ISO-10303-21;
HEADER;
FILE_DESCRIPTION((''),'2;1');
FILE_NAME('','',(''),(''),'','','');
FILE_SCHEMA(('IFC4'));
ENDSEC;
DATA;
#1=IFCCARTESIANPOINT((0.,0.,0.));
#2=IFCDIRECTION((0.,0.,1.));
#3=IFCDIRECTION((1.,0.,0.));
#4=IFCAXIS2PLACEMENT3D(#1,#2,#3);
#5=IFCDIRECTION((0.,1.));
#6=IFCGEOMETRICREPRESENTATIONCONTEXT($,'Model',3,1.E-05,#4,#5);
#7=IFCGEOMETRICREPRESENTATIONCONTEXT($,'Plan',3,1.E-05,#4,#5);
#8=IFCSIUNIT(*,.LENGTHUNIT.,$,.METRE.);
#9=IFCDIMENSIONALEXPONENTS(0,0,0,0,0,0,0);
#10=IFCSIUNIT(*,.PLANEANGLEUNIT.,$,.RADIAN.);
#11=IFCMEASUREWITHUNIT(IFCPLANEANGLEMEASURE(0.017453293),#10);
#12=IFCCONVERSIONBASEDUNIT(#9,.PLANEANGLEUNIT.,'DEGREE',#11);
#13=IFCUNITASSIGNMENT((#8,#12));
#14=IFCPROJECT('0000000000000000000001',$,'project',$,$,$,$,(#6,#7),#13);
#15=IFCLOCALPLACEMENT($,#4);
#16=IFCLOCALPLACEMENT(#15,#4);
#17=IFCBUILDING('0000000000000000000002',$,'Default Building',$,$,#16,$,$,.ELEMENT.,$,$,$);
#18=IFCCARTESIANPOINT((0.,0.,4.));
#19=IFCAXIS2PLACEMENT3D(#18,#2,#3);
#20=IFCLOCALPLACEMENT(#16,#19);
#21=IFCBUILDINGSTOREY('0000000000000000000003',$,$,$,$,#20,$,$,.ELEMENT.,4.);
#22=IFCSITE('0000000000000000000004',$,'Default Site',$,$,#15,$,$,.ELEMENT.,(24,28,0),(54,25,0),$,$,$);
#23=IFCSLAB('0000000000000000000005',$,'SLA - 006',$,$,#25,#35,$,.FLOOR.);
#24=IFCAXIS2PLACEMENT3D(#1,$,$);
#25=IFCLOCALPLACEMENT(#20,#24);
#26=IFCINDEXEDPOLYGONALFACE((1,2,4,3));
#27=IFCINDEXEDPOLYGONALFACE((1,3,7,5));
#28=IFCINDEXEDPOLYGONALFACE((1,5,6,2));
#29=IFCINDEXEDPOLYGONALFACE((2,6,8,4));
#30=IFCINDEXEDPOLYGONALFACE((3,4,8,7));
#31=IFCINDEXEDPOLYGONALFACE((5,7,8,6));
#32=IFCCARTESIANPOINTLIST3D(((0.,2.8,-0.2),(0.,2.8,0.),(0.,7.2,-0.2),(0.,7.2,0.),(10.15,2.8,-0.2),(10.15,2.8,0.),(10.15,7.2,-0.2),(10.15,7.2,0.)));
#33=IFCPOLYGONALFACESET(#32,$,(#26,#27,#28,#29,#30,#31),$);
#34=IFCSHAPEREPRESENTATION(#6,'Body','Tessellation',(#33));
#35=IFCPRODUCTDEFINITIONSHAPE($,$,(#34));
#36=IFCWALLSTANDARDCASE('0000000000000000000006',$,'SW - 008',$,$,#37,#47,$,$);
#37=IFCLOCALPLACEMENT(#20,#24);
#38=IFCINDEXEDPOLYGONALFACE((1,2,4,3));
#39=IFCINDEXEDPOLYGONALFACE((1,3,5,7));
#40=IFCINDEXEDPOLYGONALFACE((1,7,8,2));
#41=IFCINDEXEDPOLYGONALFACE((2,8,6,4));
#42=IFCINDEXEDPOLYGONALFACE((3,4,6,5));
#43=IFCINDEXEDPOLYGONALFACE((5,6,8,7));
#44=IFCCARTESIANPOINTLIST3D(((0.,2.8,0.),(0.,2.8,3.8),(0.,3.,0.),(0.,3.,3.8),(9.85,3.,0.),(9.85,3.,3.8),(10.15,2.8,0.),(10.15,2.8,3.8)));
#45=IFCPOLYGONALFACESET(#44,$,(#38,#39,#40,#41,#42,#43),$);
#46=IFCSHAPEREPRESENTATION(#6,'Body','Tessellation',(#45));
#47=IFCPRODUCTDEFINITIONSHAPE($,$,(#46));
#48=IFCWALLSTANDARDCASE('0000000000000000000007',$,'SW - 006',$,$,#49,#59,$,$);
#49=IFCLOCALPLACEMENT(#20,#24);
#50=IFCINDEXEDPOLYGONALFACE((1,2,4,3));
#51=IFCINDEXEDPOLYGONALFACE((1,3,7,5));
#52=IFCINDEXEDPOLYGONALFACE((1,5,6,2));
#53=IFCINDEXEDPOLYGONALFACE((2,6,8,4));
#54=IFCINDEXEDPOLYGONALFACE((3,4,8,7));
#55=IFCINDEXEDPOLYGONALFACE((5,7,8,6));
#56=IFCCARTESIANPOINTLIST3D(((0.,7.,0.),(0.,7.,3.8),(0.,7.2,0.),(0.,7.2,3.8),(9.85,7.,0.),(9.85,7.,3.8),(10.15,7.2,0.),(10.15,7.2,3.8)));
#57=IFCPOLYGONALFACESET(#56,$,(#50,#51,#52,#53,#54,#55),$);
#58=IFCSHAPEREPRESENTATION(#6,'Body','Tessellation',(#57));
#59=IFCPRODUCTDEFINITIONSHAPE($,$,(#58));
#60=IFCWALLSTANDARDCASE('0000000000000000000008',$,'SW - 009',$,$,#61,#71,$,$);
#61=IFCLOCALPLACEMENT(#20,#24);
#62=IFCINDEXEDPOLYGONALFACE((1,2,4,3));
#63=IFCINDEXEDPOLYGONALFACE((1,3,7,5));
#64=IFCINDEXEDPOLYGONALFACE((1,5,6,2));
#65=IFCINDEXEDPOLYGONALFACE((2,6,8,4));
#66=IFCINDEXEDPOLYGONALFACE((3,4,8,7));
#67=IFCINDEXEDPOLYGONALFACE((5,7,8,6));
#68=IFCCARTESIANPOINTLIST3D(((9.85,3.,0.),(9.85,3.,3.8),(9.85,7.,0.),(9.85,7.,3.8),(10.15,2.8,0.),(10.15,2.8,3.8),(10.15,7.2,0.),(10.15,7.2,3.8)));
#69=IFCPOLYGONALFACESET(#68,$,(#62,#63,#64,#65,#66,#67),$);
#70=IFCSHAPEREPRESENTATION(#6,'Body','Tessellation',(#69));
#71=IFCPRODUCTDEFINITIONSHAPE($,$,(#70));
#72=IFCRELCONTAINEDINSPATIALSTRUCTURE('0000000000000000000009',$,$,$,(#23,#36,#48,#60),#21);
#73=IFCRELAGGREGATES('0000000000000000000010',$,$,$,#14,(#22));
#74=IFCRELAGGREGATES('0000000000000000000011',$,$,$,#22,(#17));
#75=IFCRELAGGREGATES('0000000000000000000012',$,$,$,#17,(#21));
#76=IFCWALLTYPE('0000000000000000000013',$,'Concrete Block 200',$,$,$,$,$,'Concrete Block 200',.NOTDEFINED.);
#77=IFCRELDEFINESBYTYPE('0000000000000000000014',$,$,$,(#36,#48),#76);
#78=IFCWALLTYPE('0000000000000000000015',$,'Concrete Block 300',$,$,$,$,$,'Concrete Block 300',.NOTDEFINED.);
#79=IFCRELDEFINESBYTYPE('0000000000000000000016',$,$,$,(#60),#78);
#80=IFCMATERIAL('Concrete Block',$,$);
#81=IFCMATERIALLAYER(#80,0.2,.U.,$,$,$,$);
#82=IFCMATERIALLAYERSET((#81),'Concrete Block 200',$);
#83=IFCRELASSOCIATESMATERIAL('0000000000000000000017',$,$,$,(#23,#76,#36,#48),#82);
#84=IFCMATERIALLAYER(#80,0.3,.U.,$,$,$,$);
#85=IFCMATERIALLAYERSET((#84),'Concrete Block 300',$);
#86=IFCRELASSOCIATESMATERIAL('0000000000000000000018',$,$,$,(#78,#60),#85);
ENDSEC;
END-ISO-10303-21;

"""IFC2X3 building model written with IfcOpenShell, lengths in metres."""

from ifc_helpers import new_model, entity, si_unit, converted_unit, direction, frame, origin_with_axes, place, context, project, spatial, polyline, outline, extrude, material, layer, layer_set, layer_usage, type_object, element, save


model = new_model("IFC2X3")

# Units and contexts
model_context = context("Model", 3, precision=1e-05, world=origin_with_axes(), true_north=direction((0.0, 1.0)))
plan_context = context("Plan", 3, precision=1e-05, world=origin_with_axes(), true_north=direction((0.0, 1.0)))
ifc_project = project(units=[si_unit("LENGTHUNIT", "METRE"), converted_unit("PLANEANGLEUNIT", "DEGREE", entity("IfcPlaneAngleMeasure", 0.017453293), si_unit("PLANEANGLEUNIT", "RADIAN"), dimensions=[0, 0, 0, 0, 0, 0, 0])], contexts=[model_context, plan_context])

# Site, building, storey
site_placement = place(None, origin_with_axes())
site = spatial("IfcSite", under=ifc_project, at=site_placement, Name="Default Site", CompositionType="ELEMENT", RefLatitude=(24, 28, 0), RefLongitude=(54, 25, 0))
building_placement = place(site_placement, origin_with_axes())
building = spatial("IfcBuilding", under=site, at=building_placement, Name="Default Building", CompositionType="ELEMENT")
storey_placement = place(building_placement, frame((0.0, 0.0, 4.0), z_axis=(0.0, 0.0, 1.0), x_axis=(1.0, 0.0, 0.0)))
storey = spatial("IfcBuildingStorey", under=building, at=storey_placement, CompositionType="ELEMENT", Elevation=4.0)

# Slab
ifc_material = material(Name="Concrete Block")
ifc_layer_1 = layer(ifc_material, 0.2, ventilated="UNKNOWN")
ifc_layer_set_1 = layer_set([ifc_layer_1], Name="Concrete Block 200")
ifc_layer_usage_1 = layer_usage(ifc_layer_set_1, "AXIS3", "NEGATIVE", 0.2)
slab_placement = place(storey_placement, frame((0.0, 7.2, -0.2), z_axis=(0.0, 0.0, 1.0), x_axis=(0.0, -1.0, 0.0)))
element("IfcSlab", 1, at=slab_placement, inside=storey, material=ifc_layer_usage_1, Name="SLA - 006", PredefinedType="FLOOR", context=model_context, shape_type="SweptSolid", body=[
    extrude(outline(polyline([(0.0, 0.0), (4.4, 0.0), (4.4, 10.15), (0.0, 10.15), (0.0, 0.0)])), origin_with_axes(), (0.0, 0.0, 1.0), 0.2),
])

# Walls
ifc_layer_usage_2 = layer_usage(ifc_layer_set_1, "AXIS2", "NEGATIVE", 0.0)
wall_type_1 = type_object("IfcWallType", Name="Concrete Block 200", ElementType="Concrete Block 200", PredefinedType="NOTDEFINED", material=ifc_layer_set_1)
wall_1_placement = place(storey_placement, frame((10.15, 2.8, 0.0), z_axis=(0.0, 0.0, 1.0), x_axis=(-1.0, 0.0, 0.0)))
element("IfcWallStandardCase", 2, at=wall_1_placement, inside=storey, type_object=wall_type_1, material=ifc_layer_usage_2, Name="SW - 008", context=model_context, shape_type="SweptSolid", body=[
    extrude(outline(polyline([(0.3, -0.2), (10.15, -0.2), (10.15, 0.0), (0.0, 0.0), (0.3, -0.2)])), origin_with_axes(), (0.0, 0.0, 1.0), 3.8),
])
ifc_layer_usage_3 = layer_usage(ifc_layer_set_1, "AXIS2", "NEGATIVE", 0.0)
wall_2_placement = place(storey_placement, frame((0.0, 7.2, 0.0), z_axis=(0.0, 0.0, 1.0), x_axis=(1.0, 0.0, 0.0)))
element("IfcWallStandardCase", 3, at=wall_2_placement, inside=storey, type_object=wall_type_1, material=ifc_layer_usage_3, Name="SW - 006", context=model_context, shape_type="SweptSolid", body=[
    extrude(outline(polyline([(0.0, -0.2), (9.85, -0.2), (10.15, 0.0), (0.0, 0.0), (0.0, -0.2)])), origin_with_axes(), (0.0, 0.0, 1.0), 3.8),
])
ifc_layer_2 = layer(ifc_material, 0.3, ventilated="UNKNOWN")
ifc_layer_set_2 = layer_set([ifc_layer_2], Name="Concrete Block 300")
ifc_layer_usage_4 = layer_usage(ifc_layer_set_2, "AXIS2", "POSITIVE", 0.0)
wall_type_2 = type_object("IfcWallType", Name="Concrete Block 300", ElementType="Concrete Block 300", PredefinedType="NOTDEFINED", material=ifc_layer_set_2)
wall_3_placement = place(storey_placement, frame((10.15, 2.8, 0.0), z_axis=(0.0, 0.0, 1.0), x_axis=(0.0, 1.0, 0.0)))
element("IfcWallStandardCase", 4, at=wall_3_placement, inside=storey, type_object=wall_type_2, material=ifc_layer_usage_4, Name="SW - 009", context=model_context, shape_type="SweptSolid", body=[
    extrude(outline(polyline([(0.0, 0.0), (4.4, 0.0), (4.2, 0.3), (0.2, 0.3), (0.0, 0.0)])), origin_with_axes(), (0.0, 0.0, 1.0), 3.8),
])

save(model, "model.ifc")
